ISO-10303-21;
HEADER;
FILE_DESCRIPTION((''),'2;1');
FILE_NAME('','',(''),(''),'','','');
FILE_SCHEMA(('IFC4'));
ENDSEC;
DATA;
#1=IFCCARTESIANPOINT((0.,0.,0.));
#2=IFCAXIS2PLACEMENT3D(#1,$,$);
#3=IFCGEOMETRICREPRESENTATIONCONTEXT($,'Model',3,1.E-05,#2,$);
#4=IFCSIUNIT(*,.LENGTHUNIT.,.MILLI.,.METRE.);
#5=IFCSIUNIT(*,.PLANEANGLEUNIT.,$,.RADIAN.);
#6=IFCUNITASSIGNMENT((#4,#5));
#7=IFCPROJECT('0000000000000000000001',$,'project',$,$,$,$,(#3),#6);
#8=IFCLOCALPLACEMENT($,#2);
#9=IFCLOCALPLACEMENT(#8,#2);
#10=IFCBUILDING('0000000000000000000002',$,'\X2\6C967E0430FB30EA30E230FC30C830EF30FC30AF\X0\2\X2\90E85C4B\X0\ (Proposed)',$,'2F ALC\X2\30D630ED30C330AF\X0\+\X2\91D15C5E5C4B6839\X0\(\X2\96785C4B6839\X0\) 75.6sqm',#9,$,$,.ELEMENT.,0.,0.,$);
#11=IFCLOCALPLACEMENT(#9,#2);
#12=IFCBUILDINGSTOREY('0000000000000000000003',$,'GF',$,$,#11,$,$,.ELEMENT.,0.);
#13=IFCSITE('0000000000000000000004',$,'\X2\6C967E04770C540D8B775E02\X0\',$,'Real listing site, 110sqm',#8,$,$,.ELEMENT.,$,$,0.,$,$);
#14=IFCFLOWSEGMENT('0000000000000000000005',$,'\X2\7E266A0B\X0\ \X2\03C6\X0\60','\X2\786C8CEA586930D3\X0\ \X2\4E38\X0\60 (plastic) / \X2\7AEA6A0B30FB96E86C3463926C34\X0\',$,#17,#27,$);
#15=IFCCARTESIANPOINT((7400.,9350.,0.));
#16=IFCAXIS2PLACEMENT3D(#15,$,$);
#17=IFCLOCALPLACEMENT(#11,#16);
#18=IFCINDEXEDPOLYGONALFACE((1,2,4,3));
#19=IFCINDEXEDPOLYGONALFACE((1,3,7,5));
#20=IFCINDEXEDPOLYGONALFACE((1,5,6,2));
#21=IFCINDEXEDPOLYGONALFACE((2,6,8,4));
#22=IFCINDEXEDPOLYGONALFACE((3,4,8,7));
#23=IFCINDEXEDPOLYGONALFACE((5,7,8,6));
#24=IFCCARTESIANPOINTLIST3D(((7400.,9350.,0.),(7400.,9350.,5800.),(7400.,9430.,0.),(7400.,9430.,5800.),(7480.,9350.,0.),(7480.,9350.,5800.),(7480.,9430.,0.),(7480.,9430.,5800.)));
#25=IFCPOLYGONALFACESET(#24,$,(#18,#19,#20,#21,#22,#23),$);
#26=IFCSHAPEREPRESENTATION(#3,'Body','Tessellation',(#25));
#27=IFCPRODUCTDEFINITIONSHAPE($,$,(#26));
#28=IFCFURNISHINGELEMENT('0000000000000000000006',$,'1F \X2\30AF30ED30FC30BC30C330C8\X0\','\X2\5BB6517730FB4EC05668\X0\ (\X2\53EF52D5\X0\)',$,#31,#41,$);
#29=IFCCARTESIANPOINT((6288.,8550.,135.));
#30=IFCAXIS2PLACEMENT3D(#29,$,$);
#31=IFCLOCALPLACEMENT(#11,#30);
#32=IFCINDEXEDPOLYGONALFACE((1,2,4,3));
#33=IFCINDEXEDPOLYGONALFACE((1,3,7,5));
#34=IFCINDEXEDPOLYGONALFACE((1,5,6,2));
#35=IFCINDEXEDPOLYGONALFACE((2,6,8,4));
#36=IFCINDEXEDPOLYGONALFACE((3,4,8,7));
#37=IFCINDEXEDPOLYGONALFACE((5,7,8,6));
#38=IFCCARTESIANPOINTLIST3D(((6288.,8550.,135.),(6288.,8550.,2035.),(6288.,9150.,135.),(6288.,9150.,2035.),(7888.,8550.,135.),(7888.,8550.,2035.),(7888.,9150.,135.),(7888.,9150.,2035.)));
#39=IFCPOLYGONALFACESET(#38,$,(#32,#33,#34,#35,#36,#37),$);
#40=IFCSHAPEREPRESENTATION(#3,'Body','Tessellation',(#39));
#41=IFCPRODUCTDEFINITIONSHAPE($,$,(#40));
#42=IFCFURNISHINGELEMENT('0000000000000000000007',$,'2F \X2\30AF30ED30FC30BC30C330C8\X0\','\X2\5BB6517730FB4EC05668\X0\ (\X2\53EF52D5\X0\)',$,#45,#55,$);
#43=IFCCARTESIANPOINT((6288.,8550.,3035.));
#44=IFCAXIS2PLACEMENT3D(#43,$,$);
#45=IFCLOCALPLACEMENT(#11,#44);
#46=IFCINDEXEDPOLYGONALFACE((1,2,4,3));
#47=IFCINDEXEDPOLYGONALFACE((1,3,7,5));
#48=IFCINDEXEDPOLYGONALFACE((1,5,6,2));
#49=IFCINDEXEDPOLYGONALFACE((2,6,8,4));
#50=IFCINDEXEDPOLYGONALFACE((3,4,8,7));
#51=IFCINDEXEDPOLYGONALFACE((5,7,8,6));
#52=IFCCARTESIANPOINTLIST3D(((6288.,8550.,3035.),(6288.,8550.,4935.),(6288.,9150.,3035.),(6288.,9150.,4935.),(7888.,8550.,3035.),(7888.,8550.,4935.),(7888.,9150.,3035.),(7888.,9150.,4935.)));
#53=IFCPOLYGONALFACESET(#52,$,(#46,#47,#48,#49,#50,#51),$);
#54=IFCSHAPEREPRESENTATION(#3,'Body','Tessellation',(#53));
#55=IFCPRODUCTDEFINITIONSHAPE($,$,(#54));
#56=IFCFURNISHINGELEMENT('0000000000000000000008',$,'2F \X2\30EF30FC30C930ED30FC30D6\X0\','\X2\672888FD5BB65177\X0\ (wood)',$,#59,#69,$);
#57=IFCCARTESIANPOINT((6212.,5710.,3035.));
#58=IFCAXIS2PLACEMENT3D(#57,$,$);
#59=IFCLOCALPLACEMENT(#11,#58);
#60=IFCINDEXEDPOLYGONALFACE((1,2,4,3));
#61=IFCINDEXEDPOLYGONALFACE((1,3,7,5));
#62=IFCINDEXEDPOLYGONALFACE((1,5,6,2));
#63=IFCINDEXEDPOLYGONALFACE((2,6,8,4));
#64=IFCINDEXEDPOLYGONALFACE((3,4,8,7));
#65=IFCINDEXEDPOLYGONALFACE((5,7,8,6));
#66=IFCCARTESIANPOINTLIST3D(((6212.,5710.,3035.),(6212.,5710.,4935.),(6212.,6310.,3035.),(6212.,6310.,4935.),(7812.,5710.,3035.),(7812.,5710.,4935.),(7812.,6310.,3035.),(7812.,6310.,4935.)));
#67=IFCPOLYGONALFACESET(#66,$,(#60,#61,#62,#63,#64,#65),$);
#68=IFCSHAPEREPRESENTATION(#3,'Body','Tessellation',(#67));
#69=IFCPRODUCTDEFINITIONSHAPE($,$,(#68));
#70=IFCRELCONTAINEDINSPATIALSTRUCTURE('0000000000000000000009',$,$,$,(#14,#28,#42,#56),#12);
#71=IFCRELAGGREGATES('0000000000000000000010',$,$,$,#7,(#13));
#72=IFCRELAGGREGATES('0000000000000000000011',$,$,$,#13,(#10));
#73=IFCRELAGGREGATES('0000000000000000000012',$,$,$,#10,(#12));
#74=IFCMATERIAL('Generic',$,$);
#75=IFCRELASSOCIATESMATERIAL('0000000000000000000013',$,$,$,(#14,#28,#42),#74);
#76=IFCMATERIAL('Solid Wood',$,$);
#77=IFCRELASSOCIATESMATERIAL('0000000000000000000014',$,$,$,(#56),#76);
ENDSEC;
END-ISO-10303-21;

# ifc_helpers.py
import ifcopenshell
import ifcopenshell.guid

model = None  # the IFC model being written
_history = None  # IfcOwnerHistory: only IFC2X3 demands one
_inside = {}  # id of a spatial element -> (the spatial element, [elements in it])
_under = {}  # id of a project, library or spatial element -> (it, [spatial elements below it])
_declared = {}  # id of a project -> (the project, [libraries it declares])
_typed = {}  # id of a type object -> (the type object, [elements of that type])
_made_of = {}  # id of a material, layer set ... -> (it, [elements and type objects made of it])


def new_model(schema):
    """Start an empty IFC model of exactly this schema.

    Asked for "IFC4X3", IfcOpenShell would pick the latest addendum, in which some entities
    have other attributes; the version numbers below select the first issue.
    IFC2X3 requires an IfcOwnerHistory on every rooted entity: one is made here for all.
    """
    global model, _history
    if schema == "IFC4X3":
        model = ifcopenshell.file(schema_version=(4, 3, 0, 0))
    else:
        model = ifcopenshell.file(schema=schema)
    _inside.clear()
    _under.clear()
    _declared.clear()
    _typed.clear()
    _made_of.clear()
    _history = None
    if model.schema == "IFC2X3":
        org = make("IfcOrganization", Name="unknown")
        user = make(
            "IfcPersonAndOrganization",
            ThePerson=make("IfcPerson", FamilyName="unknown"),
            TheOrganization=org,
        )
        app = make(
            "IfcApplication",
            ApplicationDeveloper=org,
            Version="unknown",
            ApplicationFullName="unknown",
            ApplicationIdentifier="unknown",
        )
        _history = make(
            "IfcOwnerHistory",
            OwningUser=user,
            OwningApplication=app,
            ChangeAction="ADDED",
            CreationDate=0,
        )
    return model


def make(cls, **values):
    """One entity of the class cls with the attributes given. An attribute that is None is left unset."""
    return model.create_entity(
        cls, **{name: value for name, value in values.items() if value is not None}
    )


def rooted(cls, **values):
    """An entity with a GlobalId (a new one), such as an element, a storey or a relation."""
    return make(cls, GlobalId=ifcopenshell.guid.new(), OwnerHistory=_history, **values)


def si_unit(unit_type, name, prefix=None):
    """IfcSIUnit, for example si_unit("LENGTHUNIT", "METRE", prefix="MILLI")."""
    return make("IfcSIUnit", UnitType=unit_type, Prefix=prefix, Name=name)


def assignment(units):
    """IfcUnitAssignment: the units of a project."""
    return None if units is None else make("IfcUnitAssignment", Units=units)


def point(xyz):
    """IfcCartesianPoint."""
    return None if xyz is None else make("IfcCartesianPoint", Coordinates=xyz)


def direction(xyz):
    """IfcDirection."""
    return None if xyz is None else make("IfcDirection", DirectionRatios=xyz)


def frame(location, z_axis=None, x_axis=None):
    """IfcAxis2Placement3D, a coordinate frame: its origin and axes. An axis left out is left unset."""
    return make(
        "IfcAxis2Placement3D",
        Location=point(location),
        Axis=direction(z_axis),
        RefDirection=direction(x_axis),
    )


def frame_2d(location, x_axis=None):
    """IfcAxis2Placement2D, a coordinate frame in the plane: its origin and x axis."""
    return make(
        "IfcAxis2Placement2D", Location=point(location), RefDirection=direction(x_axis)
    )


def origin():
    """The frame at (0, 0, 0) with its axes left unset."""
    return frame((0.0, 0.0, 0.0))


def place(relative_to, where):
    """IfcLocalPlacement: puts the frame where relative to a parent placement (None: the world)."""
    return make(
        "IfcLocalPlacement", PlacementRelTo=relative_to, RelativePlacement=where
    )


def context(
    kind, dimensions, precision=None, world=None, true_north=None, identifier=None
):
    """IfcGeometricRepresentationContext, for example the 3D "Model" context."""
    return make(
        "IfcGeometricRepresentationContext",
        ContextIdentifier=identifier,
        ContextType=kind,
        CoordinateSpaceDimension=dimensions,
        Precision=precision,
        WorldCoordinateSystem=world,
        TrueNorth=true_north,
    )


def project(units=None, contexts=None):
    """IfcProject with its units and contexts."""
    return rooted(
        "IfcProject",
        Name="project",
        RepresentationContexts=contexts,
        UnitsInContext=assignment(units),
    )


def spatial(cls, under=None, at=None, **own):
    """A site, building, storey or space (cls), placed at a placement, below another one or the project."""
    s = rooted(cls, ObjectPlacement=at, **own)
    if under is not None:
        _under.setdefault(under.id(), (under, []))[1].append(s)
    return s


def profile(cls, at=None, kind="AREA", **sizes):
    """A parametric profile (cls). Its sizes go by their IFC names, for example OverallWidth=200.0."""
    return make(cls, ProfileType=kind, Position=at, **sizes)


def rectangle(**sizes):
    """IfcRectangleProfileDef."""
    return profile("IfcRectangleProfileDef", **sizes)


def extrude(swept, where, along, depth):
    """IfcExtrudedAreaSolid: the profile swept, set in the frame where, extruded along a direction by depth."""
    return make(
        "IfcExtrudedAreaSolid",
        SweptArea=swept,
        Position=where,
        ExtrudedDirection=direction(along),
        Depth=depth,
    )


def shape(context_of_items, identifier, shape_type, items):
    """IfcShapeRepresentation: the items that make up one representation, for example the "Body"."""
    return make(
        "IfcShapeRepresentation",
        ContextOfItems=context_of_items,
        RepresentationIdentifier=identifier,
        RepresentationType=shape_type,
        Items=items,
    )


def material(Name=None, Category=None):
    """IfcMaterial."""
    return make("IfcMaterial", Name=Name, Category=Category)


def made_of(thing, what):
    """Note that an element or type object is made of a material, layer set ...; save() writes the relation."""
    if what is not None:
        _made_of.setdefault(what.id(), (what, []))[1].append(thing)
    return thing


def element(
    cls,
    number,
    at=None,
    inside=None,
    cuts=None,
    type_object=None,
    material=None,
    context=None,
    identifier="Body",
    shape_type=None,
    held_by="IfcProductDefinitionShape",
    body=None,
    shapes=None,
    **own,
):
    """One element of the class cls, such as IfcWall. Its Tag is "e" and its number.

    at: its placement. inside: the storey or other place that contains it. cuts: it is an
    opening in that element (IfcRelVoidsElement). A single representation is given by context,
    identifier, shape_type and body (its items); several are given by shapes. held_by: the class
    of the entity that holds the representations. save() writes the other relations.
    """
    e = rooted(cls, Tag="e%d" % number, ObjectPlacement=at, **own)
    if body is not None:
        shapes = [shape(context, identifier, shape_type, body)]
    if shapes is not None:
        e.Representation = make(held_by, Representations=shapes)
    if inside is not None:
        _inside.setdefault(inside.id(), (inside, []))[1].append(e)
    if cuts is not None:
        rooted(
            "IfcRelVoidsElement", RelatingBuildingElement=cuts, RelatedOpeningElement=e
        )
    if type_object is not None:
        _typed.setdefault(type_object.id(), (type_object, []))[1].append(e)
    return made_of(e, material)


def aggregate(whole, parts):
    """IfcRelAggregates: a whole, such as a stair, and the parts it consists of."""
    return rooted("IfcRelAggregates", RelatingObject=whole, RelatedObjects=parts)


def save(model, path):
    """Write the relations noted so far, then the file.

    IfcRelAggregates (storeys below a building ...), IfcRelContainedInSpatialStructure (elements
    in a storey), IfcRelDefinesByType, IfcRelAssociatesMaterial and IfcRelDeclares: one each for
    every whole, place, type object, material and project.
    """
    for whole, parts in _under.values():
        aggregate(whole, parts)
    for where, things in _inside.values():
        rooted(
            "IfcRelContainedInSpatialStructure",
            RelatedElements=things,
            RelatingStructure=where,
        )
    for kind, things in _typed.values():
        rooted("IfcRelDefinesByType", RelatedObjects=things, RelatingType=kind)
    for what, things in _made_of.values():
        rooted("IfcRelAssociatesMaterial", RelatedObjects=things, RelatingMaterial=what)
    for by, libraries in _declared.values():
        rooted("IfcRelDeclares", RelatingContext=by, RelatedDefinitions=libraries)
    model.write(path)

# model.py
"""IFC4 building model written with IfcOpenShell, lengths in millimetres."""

from ifc_helpers import new_model, si_unit, frame, frame_2d, origin, place, context, project, spatial, rectangle, extrude, material, element, save


model = new_model("IFC4")

# Units and contexts
model_context = context("Model", 3, precision=1e-05, world=origin())
ifc_project = project(units=[si_unit("LENGTHUNIT", "METRE", prefix="MILLI"), si_unit("PLANEANGLEUNIT", "RADIAN")], contexts=[model_context])

# Site, building, storey
site_placement = place(None, origin())
site = spatial("IfcSite", under=ifc_project, at=site_placement, Name="沖縄県名護市", ObjectType="Real listing site, 110sqm", CompositionType="ELEMENT", RefElevation=0.0)
building_placement = place(site_placement, origin())
building = spatial("IfcBuilding", under=site, at=building_placement, Name="沖縄・リモートワーク2部屋 (Proposed)", ObjectType="2F ALCブロック+金属屋根(陸屋根) 75.6sqm", CompositionType="ELEMENT", ElevationOfRefHeight=0.0, ElevationOfTerrain=0.0)
storey_placement = place(building_placement, origin())
storey = spatial("IfcBuildingStorey", under=building, at=storey_placement, Name="GF", CompositionType="ELEMENT", Elevation=0.0)

# Shared definitions
ifc_material_1 = material(Name="Solid Wood")

# Shared definitions
ifc_material_2 = material(Name="Generic")

# Flow segment
flow_segment_placement = place(storey_placement, frame((7400.0, 9350.0, 0.0)))
element("IfcFlowSegment", 1, at=flow_segment_placement, inside=storey, material=ifc_material_2, Name="縦樋 φ60", Description="硬質塩ビ 丸60 (plastic) / 竪樋・雨水排水", context=model_context, shape_type="SweptSolid", body=[
    extrude(rectangle(XDim=80.0, YDim=80.0, at=frame_2d((40.0, 40.0))), frame((7400.0, 9350.0, 0.0)), (0.0, 0.0, 1.0), 5800.0),
])

# Furnishing elements
furnishing_1_placement = place(storey_placement, frame((6288.0, 8550.0, 135.0)))
element("IfcFurnishingElement", 2, at=furnishing_1_placement, inside=storey, material=ifc_material_2, Name="1F クローゼット", Description="家具・什器 (可動)", context=model_context, shape_type="SweptSolid", body=[
    extrude(rectangle(XDim=1600.0, YDim=600.0, at=frame_2d((800.0, 300.0))), frame((6288.0, 8550.0, 135.0)), (0.0, 0.0, 1.0), 1900.0),
])
furnishing_2_placement = place(storey_placement, frame((6288.0, 8550.0, 3035.0)))
element("IfcFurnishingElement", 3, at=furnishing_2_placement, inside=storey, material=ifc_material_2, Name="2F クローゼット", Description="家具・什器 (可動)", context=model_context, shape_type="SweptSolid", body=[
    extrude(rectangle(XDim=1600.0, YDim=600.0, at=frame_2d((800.0, 300.0))), frame((6288.0, 8550.0, 3035.0)), (0.0, 0.0, 1.0), 1900.0),
])
furnishing_3_placement = place(storey_placement, frame((6212.0, 5710.0, 3035.0)))
element("IfcFurnishingElement", 4, at=furnishing_3_placement, inside=storey, material=ifc_material_1, Name="2F ワードローブ", Description="木製家具 (wood)", context=model_context, shape_type="SweptSolid", body=[
    extrude(rectangle(XDim=1600.0, YDim=600.0, at=frame_2d((800.0, 300.0))), frame((6212.0, 5710.0, 3035.0)), (0.0, 0.0, 1.0), 1900.0),
])

save(model, "model.ifc")
